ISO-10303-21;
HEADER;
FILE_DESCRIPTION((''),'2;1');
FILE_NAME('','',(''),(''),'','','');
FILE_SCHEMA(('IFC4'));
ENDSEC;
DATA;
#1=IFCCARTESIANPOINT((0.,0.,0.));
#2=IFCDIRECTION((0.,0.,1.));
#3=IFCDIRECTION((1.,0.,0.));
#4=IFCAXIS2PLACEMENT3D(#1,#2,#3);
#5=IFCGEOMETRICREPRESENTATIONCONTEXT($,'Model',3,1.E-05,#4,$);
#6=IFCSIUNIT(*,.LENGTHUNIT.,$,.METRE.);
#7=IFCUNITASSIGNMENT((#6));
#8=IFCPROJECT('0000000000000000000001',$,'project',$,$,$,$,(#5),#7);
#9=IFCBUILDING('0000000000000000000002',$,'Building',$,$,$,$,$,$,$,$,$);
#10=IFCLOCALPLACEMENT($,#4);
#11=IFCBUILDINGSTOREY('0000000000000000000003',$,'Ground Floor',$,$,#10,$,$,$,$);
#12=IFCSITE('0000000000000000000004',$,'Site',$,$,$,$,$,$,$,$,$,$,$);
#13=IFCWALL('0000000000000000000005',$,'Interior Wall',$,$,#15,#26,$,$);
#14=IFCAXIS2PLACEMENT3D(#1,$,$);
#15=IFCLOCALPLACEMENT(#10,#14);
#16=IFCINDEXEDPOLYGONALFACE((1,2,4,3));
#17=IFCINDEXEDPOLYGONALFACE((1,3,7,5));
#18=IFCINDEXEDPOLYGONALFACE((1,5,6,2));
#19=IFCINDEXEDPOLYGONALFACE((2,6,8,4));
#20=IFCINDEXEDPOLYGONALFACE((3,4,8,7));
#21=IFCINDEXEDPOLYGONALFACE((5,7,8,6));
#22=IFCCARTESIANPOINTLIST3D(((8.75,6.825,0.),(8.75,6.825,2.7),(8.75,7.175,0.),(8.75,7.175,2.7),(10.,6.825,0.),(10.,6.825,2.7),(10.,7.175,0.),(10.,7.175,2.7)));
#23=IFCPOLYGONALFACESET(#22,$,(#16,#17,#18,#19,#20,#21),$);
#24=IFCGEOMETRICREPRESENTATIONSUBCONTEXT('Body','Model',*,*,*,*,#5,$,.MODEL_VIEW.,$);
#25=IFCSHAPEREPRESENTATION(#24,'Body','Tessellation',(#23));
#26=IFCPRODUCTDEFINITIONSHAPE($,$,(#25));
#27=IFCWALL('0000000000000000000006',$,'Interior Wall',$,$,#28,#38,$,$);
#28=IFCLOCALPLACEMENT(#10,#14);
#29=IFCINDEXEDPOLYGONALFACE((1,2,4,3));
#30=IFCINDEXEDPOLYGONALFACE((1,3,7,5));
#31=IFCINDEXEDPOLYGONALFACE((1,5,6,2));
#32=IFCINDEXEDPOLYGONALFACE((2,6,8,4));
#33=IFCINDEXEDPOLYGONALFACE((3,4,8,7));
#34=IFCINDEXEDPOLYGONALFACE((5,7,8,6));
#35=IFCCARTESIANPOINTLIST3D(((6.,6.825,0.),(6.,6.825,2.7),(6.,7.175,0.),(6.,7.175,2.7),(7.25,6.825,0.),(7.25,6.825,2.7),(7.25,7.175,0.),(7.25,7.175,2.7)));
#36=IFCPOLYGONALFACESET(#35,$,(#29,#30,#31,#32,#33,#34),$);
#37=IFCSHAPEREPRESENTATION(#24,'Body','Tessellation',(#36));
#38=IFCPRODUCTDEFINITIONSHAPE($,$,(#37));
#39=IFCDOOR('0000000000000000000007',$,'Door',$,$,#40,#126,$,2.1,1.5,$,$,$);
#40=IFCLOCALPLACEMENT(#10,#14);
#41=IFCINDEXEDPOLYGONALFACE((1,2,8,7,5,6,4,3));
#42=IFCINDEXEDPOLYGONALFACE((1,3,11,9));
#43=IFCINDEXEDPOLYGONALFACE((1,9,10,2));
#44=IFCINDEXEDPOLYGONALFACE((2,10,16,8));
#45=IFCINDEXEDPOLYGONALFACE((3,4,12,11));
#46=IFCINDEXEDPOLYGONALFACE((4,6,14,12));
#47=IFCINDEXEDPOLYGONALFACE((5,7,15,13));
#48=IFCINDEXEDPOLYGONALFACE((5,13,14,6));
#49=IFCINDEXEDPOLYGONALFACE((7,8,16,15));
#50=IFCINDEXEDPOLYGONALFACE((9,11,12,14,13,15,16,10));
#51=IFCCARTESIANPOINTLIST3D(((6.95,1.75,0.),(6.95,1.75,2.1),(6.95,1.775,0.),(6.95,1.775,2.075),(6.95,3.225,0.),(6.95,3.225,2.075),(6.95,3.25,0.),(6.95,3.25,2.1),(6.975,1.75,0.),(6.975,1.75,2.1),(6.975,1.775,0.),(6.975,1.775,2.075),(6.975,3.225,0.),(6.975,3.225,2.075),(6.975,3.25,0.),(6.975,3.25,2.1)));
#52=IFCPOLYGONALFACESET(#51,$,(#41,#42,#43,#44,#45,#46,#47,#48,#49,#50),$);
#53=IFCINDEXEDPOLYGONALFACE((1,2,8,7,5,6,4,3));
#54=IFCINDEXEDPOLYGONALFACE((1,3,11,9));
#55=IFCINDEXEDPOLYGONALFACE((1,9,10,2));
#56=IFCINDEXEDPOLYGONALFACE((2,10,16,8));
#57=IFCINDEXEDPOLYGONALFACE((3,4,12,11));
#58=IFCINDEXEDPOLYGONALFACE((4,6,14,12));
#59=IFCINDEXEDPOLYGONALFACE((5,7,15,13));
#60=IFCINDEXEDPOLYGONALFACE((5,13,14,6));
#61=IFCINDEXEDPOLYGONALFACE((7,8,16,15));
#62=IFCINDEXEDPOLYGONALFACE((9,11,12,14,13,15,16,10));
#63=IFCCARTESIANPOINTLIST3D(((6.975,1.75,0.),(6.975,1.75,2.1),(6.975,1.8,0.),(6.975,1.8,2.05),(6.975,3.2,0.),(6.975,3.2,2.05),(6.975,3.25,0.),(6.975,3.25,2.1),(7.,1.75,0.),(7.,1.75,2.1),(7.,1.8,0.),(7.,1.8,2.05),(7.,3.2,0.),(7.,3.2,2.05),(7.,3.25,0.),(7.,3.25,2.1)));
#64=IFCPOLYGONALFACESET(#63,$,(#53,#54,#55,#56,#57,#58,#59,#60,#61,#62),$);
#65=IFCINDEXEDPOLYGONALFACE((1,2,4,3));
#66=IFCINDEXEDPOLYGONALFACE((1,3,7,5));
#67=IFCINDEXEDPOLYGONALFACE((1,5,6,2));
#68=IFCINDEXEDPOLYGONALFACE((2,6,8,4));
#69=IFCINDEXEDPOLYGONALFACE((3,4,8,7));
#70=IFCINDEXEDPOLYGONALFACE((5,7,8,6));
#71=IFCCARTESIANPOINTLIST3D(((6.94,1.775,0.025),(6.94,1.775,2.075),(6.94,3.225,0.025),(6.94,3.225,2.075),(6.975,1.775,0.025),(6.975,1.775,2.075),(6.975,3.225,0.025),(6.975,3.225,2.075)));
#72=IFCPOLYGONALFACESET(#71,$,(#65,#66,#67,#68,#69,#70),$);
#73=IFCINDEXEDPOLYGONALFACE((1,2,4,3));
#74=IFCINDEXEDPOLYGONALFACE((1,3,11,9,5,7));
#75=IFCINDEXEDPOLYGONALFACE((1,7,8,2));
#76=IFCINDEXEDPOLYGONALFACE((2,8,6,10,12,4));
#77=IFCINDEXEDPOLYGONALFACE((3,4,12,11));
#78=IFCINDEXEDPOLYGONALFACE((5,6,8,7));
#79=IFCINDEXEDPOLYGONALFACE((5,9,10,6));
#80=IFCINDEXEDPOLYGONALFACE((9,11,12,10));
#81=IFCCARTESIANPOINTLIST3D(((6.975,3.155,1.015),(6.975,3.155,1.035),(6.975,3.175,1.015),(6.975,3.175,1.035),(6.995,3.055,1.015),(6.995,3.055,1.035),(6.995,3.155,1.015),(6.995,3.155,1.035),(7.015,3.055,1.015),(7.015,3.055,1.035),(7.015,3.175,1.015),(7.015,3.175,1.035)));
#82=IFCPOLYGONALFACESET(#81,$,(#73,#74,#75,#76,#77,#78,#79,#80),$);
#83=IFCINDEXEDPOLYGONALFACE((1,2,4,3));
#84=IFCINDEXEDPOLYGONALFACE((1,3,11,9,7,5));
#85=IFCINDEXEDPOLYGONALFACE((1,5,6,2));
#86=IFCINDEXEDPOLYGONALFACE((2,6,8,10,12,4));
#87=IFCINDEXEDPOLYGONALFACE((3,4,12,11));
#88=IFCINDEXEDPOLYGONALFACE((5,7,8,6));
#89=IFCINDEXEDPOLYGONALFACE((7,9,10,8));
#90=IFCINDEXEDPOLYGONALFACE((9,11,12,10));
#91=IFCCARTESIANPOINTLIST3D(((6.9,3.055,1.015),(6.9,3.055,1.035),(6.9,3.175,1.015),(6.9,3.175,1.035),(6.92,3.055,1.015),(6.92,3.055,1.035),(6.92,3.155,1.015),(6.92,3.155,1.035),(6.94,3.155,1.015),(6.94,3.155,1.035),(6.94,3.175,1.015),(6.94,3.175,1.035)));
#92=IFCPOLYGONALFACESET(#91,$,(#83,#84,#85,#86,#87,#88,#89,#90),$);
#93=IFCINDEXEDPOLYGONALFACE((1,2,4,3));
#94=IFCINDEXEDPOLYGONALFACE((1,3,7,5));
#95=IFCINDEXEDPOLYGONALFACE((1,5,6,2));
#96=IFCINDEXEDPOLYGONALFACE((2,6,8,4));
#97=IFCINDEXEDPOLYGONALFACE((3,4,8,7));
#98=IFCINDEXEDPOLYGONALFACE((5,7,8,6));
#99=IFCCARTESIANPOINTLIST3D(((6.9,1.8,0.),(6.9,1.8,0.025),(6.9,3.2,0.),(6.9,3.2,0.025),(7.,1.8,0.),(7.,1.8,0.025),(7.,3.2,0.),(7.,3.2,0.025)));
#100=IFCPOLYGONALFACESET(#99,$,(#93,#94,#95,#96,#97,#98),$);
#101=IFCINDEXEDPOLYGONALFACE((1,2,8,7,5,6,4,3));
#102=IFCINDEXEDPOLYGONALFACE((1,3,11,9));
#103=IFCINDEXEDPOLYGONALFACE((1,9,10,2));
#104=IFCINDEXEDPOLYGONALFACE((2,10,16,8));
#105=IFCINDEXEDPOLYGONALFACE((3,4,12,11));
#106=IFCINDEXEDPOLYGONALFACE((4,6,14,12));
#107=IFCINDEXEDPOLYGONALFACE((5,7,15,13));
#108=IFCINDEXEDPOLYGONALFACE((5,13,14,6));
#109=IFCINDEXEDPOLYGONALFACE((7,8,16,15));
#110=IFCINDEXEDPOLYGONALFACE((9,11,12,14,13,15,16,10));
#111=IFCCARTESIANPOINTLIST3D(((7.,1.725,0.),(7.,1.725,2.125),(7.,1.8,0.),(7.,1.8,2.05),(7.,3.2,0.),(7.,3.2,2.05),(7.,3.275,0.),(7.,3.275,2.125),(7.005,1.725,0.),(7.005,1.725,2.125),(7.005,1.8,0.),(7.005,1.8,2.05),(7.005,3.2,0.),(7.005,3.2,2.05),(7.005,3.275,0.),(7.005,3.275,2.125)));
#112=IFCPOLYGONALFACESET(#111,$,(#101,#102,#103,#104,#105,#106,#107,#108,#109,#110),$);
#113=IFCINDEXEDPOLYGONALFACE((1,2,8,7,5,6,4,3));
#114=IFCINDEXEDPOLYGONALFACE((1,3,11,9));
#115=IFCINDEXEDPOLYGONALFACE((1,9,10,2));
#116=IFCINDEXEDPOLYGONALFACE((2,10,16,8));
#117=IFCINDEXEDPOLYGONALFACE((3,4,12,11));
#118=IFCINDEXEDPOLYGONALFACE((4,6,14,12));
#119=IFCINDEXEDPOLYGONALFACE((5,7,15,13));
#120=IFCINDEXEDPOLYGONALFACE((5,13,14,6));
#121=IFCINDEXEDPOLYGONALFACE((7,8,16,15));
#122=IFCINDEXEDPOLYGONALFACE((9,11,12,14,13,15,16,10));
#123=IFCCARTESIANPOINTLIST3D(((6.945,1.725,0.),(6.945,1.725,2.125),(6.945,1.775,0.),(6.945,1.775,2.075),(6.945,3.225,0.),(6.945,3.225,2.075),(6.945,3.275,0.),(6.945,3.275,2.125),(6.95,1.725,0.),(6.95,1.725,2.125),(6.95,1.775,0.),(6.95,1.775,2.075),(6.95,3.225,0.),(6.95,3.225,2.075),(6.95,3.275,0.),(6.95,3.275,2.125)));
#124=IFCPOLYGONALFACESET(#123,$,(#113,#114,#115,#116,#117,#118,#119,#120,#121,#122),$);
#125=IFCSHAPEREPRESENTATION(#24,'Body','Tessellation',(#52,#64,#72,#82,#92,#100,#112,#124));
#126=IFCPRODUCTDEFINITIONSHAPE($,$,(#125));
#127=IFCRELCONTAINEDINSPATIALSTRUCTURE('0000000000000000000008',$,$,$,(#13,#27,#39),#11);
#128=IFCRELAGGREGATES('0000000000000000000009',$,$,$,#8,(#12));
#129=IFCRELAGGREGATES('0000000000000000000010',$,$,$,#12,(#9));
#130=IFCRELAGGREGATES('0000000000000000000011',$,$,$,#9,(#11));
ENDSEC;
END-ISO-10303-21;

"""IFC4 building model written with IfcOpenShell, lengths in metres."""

from ifc_helpers import new_model, si_unit, frame, origin_with_axes, place, context, subcontext, project, spatial, line, indexed_curve, outline, extrude, element, save


model = new_model("IFC4")

# Units and contexts
model_context = context("Model", 3, precision=1e-05, world=origin_with_axes())
body_context = subcontext(model_context, "Body", "Model", "MODEL_VIEW")
ifc_project = project(units=[si_unit("LENGTHUNIT", "METRE")], contexts=[model_context])

# Site, building, storey
site = spatial("IfcSite", under=ifc_project, Name="Site")
building = spatial("IfcBuilding", under=site, Name="Building")
storey_placement = place(None, origin_with_axes())
storey = spatial("IfcBuildingStorey", under=building, at=storey_placement, Name="Ground Floor")

# Walls
for number, where, z_axis, x_axis, name in (
    (1, (10.0, 7.0, 0.0), (0.0, 0.0, 1.0), (-1.0, 0.0, 0.0), "Interior Wall"),
    (2, (7.25, 7.0, 0.0), (0.0, 0.0, 1.0), (-1.0, 0.0, 0.0), "Interior Wall"),
):
    element("IfcWall", number, at=place(storey_placement, frame(where, z_axis=z_axis, x_axis=x_axis)), inside=storey, Name=name, context=body_context, shape_type="SweptSolid", body=[
        extrude(outline(indexed_curve([(0.0, 0.0), (0.0, 0.35), (1.25, 0.35), (1.25, 0.0), (0.0, 0.0)], self_intersect=False)), frame((0.0, -0.175, 0.0), z_axis=(0.0, 0.0, 1.0), x_axis=(1.0, 0.0, 0.0)), (0.0, 0.0, 1.0), 2.7),
    ])

# Door
door_1_placement = place(storey_placement, frame((7.0, 1.75, 0.0), z_axis=(0.0, 0.0, 1.0), x_axis=(0.0, 1.0, 0.0)))
element("IfcDoor", 3, at=door_1_placement, inside=storey, Name="Door", OverallHeight=2.1, OverallWidth=1.5, context=body_context, shape_type="SweptSolid", body=[
    extrude(outline(indexed_curve([(0.0, 0.0), (0.0, 2.1), (1.5, 2.1), (1.5, 0.0), (1.475, 0.0), (1.475, 2.075), (0.025, 2.075), (0.025, 0.0)], segments=[line(1, 2, 3, 4, 5, 6, 7, 8, 1)])), frame((0.0, 0.025, 0.0), z_axis=(0.0, -1.0, 0.0), x_axis=(1.0, 0.0, 0.0)), (0.0, 0.0, -1.0), 0.025),
    extrude(outline(indexed_curve([(0.0, 0.0), (0.0, 2.1), (1.5, 2.1), (1.5, 0.0), (1.45, 0.0), (1.45, 2.05), (0.05, 2.05), (0.05, 0.0)], segments=[line(1, 2, 3, 4, 5, 6, 7, 8, 1)])), frame((0.0, 0.0, 0.0), z_axis=(0.0, -1.0, 0.0), x_axis=(1.0, 0.0, 0.0)), (0.0, 0.0, -1.0), 0.025),
    extrude(outline(indexed_curve([(0.0, 0.0), (1.45, 0.0), (1.45, 0.035), (0.0, 0.035)], segments=[line(1, 2, 3, 4, 1)])), frame((0.025, 0.025, 0.025), z_axis=(0.0, 0.0, 1.0), x_axis=(1.0, 0.0, 0.0)), (0.0, 0.0, 1.0), 2.05),
    extrude(outline(indexed_curve([(0.0, 0.0), (0.0, -0.04), (-0.12, -0.04), (-0.12, -0.02), (-0.02, -0.02), (-0.02, 0.0)], segments=[line(1, 2, 3, 4, 5, 6, 1)])), frame((1.425, 0.025, 1.015), z_axis=(0.0, 0.0, 1.0), x_axis=(1.0, 0.0, 0.0)), (0.0, 0.0, 1.0), 0.02),
    extrude(outline(indexed_curve([(0.0, 0.0), (0.0, 0.04), (-0.12, 0.04), (-0.12, 0.02), (-0.02, 0.02), (-0.02, 0.0)], segments=[line(1, 2, 3, 4, 5, 6, 1)])), frame((1.425, 0.06, 1.015), z_axis=(0.0, 0.0, 1.0), x_axis=(1.0, 0.0, 0.0)), (0.0, 0.0, 1.0), 0.02),
    extrude(outline(indexed_curve([(0.0, 0.0), (1.4, 0.0), (1.4, 0.1), (0.0, 0.1)], segments=[line(1, 2, 3, 4, 1)])), frame((0.05, 0.0, 0.0), z_axis=(0.0, 0.0, 1.0), x_axis=(1.0, 0.0, 0.0)), (0.0, 0.0, 1.0), 0.025),
    extrude(outline(indexed_curve([(0.0, 0.0), (0.0, 2.125), (1.55, 2.125), (1.55, 0.0), (1.475, 0.0), (1.475, 2.05), (0.075, 2.05), (0.075, 0.0)], segments=[line(1, 2, 3, 4, 5, 6, 7, 8, 1)])), frame((-0.025, -0.005, 0.0), z_axis=(0.0, -1.0, 0.0), x_axis=(1.0, 0.0, 0.0)), (0.0, 0.0, -1.0), 0.005),
    extrude(outline(indexed_curve([(0.0, 0.0), (0.0, 2.125), (1.55, 2.125), (1.55, 0.0), (1.5, 0.0), (1.5, 2.075), (0.05, 2.075), (0.05, 0.0)], segments=[line(1, 2, 3, 4, 5, 6, 7, 8, 1)])), frame((-0.025, 0.05, 0.0), z_axis=(0.0, -1.0, 0.0), x_axis=(1.0, 0.0, 0.0)), (0.0, 0.0, -1.0), 0.005),
])

save(model, "model.ifc")
